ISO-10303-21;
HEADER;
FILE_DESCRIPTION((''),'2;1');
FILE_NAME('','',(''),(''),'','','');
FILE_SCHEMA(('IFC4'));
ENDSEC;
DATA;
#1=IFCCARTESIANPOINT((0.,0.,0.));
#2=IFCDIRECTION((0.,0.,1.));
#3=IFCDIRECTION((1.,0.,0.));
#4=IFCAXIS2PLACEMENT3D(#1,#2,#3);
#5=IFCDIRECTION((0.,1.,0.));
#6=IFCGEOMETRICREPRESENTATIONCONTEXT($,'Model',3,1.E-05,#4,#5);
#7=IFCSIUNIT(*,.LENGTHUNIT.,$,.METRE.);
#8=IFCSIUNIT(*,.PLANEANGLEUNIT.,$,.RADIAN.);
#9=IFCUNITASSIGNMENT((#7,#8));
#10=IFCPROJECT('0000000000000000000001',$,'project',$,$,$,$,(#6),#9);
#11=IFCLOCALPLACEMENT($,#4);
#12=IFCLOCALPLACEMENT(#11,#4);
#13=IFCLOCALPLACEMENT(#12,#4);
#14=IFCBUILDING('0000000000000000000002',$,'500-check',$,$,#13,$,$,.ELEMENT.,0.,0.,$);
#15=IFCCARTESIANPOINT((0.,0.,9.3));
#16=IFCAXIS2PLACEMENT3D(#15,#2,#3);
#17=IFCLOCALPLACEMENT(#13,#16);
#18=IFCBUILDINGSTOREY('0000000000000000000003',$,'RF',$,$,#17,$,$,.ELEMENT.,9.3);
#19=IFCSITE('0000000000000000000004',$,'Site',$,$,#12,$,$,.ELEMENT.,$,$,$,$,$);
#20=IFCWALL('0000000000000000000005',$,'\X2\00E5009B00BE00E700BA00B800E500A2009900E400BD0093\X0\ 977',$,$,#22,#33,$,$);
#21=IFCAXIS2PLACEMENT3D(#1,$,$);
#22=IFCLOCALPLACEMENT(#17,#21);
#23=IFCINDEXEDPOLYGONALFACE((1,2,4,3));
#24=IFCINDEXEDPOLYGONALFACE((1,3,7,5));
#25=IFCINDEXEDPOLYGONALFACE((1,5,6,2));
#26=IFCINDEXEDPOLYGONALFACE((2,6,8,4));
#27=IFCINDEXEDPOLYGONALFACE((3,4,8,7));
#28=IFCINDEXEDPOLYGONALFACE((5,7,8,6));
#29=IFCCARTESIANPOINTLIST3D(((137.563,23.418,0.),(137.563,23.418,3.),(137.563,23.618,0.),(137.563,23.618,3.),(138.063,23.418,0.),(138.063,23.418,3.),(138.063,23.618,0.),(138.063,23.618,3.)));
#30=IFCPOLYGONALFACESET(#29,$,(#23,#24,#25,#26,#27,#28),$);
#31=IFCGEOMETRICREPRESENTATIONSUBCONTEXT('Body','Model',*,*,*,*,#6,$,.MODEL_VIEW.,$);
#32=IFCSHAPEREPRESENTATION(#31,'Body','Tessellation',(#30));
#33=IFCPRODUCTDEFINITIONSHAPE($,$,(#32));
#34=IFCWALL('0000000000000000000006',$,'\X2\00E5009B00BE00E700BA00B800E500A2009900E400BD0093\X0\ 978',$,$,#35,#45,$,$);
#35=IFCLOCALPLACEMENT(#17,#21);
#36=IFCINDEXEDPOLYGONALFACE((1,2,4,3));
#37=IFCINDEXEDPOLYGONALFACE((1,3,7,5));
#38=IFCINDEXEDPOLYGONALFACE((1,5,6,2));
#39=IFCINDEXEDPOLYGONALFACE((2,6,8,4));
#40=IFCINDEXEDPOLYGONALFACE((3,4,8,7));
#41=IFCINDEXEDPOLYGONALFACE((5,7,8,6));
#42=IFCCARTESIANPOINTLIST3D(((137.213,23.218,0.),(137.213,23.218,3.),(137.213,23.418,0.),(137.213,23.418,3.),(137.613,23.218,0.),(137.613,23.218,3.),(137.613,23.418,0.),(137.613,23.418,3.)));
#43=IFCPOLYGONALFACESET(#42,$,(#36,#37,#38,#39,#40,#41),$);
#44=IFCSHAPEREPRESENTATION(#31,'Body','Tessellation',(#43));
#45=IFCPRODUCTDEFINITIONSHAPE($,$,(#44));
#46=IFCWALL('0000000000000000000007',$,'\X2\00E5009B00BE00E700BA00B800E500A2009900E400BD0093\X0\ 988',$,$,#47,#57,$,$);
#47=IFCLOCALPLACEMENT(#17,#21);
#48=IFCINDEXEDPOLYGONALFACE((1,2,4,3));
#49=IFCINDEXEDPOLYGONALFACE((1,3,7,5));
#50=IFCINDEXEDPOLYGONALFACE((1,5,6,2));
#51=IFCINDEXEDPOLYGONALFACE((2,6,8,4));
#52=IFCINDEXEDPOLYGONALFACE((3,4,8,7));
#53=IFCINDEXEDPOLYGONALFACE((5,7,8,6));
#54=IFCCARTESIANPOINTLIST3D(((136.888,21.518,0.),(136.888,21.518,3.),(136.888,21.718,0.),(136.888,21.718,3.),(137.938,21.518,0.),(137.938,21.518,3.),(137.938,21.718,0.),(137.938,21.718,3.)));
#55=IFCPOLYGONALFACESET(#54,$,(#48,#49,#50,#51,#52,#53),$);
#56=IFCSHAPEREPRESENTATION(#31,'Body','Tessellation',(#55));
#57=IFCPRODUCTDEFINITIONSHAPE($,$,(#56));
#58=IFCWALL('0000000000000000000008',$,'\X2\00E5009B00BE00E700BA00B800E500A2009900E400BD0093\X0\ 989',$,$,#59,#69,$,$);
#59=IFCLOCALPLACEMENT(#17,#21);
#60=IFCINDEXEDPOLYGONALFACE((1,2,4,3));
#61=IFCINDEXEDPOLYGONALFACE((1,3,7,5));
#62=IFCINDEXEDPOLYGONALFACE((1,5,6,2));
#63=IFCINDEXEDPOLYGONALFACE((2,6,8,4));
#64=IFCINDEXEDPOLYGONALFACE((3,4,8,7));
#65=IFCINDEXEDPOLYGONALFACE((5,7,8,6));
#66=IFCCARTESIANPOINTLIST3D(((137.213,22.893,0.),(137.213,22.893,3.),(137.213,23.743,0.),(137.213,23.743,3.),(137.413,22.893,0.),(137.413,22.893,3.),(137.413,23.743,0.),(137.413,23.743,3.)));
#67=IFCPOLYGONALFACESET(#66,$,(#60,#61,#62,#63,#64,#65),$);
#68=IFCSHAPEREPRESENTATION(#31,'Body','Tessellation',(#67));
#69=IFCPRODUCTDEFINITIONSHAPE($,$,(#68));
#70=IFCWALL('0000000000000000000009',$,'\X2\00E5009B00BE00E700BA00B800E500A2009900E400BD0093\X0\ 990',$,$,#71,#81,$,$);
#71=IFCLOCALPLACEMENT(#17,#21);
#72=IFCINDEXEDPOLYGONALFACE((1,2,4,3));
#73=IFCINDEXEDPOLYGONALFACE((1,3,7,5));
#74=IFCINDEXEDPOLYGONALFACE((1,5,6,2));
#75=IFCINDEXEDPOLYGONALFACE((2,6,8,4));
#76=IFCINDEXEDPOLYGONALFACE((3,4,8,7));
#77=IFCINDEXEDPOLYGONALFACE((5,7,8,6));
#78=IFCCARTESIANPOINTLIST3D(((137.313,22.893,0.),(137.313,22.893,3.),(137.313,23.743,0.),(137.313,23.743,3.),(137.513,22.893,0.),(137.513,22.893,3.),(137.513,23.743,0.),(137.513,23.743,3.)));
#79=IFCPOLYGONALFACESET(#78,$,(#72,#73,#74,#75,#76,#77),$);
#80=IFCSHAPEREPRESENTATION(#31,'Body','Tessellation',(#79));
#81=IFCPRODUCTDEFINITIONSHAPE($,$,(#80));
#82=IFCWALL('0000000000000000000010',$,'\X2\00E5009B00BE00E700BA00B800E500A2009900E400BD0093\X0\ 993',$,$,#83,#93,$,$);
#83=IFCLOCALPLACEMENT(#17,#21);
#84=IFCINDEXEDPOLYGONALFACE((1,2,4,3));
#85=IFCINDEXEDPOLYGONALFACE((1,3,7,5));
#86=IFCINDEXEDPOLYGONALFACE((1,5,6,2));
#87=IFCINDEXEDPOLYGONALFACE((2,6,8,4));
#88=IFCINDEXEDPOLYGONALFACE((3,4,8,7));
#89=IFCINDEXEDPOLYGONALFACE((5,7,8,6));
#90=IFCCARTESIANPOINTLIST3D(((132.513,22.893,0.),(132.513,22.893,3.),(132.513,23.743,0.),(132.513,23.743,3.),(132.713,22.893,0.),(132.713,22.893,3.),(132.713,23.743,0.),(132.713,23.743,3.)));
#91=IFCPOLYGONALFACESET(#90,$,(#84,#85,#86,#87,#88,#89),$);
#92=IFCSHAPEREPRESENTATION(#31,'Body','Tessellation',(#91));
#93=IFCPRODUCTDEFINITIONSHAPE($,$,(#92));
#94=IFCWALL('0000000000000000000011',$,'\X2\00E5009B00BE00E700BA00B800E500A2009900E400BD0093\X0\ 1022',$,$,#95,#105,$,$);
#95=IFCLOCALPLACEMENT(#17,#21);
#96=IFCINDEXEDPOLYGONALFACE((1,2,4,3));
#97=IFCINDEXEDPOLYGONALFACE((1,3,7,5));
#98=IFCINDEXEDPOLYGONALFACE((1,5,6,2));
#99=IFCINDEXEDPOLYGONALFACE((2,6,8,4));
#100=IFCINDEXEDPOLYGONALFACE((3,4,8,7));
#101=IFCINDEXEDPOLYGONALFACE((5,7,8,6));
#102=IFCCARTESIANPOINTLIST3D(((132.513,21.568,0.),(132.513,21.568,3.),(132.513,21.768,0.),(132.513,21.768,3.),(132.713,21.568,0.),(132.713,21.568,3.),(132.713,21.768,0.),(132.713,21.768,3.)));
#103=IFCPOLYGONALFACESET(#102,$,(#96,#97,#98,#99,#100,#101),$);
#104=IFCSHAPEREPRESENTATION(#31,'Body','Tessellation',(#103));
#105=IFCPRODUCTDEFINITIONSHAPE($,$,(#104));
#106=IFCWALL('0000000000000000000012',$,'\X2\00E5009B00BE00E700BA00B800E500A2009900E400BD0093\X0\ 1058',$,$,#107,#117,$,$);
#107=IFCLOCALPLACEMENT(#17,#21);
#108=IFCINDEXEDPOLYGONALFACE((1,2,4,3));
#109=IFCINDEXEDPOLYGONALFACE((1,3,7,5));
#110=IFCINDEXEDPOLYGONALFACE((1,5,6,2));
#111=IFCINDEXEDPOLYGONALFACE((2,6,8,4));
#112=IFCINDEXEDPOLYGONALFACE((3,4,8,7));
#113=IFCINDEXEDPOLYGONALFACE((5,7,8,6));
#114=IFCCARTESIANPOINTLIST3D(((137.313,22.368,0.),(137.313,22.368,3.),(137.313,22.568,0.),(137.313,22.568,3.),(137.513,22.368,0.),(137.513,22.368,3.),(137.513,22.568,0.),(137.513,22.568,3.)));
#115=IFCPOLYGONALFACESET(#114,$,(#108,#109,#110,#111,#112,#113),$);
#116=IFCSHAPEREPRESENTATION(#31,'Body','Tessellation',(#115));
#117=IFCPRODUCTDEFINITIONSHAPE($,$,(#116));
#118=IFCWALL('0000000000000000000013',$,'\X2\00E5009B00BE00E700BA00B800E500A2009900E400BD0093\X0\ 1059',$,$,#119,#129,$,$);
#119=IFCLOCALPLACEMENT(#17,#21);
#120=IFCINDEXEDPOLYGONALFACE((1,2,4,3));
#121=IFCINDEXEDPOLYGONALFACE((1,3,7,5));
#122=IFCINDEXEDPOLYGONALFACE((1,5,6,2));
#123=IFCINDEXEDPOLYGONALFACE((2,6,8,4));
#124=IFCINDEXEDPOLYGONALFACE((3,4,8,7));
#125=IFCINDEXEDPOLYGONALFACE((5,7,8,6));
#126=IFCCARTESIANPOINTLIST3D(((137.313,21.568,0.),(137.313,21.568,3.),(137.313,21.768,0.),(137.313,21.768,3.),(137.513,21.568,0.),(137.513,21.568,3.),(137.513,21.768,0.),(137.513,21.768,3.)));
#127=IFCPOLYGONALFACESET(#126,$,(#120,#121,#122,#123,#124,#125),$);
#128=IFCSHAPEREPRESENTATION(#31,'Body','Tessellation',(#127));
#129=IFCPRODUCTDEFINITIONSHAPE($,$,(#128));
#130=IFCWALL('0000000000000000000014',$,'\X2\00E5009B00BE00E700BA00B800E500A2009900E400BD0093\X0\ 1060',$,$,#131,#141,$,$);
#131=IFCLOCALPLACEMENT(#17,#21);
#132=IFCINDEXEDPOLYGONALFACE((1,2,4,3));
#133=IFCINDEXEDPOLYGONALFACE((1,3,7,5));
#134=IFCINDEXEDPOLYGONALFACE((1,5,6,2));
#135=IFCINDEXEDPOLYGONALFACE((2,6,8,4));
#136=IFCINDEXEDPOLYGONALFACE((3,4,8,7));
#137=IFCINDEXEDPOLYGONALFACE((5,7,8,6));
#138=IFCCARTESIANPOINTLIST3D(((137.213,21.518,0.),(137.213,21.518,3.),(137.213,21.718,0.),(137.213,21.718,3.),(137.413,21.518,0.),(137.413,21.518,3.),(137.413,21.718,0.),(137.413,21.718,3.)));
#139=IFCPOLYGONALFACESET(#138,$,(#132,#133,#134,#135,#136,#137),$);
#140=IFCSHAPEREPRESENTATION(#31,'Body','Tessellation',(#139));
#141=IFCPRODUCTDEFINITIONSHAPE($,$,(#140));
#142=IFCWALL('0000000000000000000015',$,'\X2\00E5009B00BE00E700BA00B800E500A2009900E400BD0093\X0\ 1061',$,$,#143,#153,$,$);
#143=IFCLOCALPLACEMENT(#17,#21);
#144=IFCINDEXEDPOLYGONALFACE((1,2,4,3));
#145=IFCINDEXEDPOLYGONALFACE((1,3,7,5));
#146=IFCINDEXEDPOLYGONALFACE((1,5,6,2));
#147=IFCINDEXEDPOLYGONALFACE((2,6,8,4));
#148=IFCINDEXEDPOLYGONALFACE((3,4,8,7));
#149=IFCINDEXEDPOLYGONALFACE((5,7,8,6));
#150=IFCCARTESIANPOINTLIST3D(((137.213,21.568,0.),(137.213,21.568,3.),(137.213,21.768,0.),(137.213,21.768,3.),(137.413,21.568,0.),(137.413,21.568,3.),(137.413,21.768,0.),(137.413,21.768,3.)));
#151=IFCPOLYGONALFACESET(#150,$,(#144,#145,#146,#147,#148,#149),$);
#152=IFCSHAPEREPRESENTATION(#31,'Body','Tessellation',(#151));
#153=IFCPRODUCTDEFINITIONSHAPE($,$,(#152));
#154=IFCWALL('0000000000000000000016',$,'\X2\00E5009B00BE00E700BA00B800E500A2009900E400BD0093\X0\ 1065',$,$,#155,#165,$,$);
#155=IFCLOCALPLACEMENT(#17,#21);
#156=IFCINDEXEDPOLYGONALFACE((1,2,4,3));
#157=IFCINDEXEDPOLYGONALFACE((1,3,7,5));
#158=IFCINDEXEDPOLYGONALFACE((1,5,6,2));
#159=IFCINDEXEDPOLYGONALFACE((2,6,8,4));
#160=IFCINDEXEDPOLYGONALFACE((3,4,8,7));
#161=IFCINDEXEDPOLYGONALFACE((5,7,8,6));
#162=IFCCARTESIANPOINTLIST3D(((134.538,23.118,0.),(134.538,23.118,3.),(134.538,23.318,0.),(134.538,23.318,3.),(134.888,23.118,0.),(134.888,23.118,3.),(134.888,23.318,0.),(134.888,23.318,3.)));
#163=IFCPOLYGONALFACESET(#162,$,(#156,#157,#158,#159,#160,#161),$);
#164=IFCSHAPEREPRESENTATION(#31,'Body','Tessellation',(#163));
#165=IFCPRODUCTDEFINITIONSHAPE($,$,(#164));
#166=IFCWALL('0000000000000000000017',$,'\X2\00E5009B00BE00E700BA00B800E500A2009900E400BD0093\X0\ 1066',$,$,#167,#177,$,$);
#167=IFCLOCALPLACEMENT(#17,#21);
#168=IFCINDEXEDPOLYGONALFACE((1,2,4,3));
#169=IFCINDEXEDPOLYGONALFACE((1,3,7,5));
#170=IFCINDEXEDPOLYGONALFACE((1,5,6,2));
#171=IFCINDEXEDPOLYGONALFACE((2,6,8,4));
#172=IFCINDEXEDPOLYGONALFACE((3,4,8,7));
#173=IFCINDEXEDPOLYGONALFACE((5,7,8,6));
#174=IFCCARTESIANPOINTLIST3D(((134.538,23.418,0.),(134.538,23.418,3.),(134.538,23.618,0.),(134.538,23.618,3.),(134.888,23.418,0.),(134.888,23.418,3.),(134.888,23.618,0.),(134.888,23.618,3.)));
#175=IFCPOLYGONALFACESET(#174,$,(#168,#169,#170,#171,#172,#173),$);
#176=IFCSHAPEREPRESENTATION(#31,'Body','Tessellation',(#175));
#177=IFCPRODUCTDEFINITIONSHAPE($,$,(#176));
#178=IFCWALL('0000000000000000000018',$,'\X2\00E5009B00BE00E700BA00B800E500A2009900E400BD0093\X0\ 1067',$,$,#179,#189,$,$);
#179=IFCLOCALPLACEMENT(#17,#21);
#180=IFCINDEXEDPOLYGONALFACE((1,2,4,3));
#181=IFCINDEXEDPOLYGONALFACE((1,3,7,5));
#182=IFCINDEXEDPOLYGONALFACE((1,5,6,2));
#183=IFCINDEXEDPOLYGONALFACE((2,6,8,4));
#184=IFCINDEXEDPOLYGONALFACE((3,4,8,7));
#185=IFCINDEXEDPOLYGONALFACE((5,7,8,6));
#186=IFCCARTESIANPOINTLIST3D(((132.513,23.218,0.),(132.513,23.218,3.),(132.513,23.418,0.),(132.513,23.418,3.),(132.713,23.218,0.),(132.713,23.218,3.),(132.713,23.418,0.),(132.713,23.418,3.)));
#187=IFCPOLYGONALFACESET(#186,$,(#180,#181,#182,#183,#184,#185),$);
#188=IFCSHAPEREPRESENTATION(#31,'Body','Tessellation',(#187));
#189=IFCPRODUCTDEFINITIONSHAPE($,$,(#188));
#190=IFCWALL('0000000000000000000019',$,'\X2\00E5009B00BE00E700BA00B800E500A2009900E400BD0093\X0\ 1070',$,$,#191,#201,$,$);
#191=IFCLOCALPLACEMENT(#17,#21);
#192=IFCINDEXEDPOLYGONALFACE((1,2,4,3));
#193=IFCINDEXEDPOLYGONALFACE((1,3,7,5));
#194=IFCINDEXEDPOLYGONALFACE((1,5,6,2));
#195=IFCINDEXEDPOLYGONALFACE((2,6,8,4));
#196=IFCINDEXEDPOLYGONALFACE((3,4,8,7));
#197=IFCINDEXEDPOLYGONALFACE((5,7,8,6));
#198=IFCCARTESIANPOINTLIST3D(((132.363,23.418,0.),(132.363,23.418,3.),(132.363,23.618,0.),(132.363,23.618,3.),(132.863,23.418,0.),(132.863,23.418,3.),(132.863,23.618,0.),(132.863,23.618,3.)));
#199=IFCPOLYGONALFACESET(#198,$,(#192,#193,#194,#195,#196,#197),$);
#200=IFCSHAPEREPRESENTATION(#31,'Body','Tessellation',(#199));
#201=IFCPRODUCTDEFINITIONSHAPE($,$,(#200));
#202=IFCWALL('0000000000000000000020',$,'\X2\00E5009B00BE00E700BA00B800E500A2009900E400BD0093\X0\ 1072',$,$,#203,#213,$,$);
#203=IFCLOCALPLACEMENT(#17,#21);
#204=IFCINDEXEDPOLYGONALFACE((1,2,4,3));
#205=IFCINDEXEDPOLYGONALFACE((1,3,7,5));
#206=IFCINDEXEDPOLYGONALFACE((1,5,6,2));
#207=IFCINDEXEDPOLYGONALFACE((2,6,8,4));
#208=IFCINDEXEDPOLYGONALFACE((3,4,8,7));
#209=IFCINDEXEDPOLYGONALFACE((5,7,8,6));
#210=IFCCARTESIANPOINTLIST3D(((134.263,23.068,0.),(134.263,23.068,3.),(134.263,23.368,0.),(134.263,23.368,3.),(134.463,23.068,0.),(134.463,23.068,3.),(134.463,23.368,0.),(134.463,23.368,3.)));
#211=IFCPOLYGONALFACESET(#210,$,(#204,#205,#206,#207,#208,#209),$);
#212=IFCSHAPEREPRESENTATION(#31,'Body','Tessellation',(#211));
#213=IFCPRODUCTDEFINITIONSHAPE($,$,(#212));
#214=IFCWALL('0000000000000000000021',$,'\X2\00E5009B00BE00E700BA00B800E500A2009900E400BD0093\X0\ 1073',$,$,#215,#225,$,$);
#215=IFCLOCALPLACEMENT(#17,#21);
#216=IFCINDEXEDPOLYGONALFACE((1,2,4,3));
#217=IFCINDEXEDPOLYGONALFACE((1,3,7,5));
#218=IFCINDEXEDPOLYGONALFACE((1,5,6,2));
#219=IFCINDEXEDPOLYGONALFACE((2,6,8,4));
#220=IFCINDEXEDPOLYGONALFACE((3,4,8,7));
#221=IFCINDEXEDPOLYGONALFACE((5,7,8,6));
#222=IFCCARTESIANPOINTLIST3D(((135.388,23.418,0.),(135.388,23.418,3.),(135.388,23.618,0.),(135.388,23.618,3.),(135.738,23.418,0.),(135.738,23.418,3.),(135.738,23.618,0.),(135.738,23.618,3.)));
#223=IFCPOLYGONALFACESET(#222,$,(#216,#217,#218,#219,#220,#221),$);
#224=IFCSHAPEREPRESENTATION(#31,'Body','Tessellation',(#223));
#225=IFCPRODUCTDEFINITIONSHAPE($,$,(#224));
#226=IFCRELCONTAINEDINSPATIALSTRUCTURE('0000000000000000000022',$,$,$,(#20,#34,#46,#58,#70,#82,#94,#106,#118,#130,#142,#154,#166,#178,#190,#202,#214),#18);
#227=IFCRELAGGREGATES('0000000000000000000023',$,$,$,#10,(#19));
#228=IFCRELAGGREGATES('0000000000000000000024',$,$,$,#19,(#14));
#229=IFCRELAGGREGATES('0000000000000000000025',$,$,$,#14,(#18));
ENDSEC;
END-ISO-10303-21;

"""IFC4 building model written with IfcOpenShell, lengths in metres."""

from ifc_helpers import new_model, si_unit, direction, frame, frame_2d, origin_with_axes, place, context, subcontext, project, spatial, rectangle, extrude, element, save


model = new_model("IFC4")

# Units and contexts
model_context = context("Model", 3, precision=1e-05, world=origin_with_axes(), true_north=direction((0.0, 1.0, 0.0)))
body_context = subcontext(model_context, "Body", "Model", "MODEL_VIEW")
ifc_project = project(units=[si_unit("LENGTHUNIT", "METRE"), si_unit("PLANEANGLEUNIT", "RADIAN")], contexts=[model_context])

# Site, building, storey
placement = place(None, origin_with_axes())
site_placement = place(placement, origin_with_axes())
site = spatial("IfcSite", under=ifc_project, at=site_placement, Name="Site", CompositionType="ELEMENT")
building_placement = place(site_placement, origin_with_axes())
building = spatial("IfcBuilding", under=site, at=building_placement, Name="500-check", CompositionType="ELEMENT", ElevationOfRefHeight=0.0, ElevationOfTerrain=0.0)
storey_placement = place(building_placement, frame((0.0, 0.0, 9.3), z_axis=(0.0, 0.0, 1.0), x_axis=(1.0, 0.0, 0.0)))
storey = spatial("IfcBuildingStorey", under=building, at=storey_placement, Name="RF", CompositionType="ELEMENT", Elevation=9.3)

# Walls
wall_1_placement = place(storey_placement, frame((137.813, 23.518, 0.0), z_axis=(0.0, 0.0, 1.0), x_axis=(-1.0, 0.0, 0.0)))
element("IfcWall", 1, at=wall_1_placement, inside=storey, Name="å\u009b¾çº¸å¢\u0099ä½\u0093 977", context=body_context, shape_type="SweptSolid", body=[
    extrude(rectangle(XDim=0.5, YDim=0.2, at=frame_2d((0.0, 0.0), x_axis=(1.0, 0.0, 0.0))), frame((0.0, 0.0, 0.0), z_axis=(0.0, 0.0, 1.0)), (0.0, 0.0, 1.0), 3.0),
])
wall_2_placement = place(storey_placement, frame((137.413, 23.318, 0.0), z_axis=(0.0, 0.0, 1.0), x_axis=(1.0, 0.0, 0.0)))
element("IfcWall", 2, at=wall_2_placement, inside=storey, Name="å\u009b¾çº¸å¢\u0099ä½\u0093 978", context=body_context, shape_type="SweptSolid", body=[
    extrude(rectangle(XDim=0.4, YDim=0.2, at=frame_2d((0.0, 0.0), x_axis=(1.0, 0.0, 0.0))), frame((0.0, 0.0, 0.0), z_axis=(0.0, 0.0, 1.0)), (0.0, 0.0, 1.0), 3.0),
])
wall_3_placement = place(storey_placement, frame((137.413, 21.618, 0.0), z_axis=(0.0, 0.0, 1.0), x_axis=(1.0, 0.0, 0.0)))
element("IfcWall", 3, at=wall_3_placement, inside=storey, Name="å\u009b¾çº¸å¢\u0099ä½\u0093 988", context=body_context, shape_type="SweptSolid", body=[
    extrude(rectangle(XDim=1.05, YDim=0.2, at=frame_2d((0.0, 0.0), x_axis=(1.0, 0.0, 0.0))), frame((0.0, 0.0, 0.0), z_axis=(0.0, 0.0, 1.0)), (0.0, 0.0, 1.0), 3.0),
])
for number, where, z_axis, x_axis, name in (
    (4, (137.313, 23.318, 0.0), (0.0, 0.0, 1.0), (0.0, -1.0, 0.0), "å\u009b¾çº¸å¢\u0099ä½\u0093 989"),
    (5, (137.413, 23.318, 0.0), (0.0, 0.0, 1.0), (0.0, -1.0, 0.0), "å\u009b¾çº¸å¢\u0099ä½\u0093 990"),
    (6, (132.613, 23.318, 0.0), (0.0, 0.0, 1.0), (0.0, -1.0, 0.0), "å\u009b¾çº¸å¢\u0099ä½\u0093 993"),
):
    element("IfcWall", number, at=place(storey_placement, frame(where, z_axis=z_axis, x_axis=x_axis)), inside=storey, Name=name, context=body_context, shape_type="SweptSolid", body=[
        extrude(rectangle(XDim=0.85, YDim=0.2, at=frame_2d((0.0, 0.0), x_axis=(1.0, 0.0, 0.0))), frame((0.0, 0.0, 0.0), z_axis=(0.0, 0.0, 1.0)), (0.0, 0.0, 1.0), 3.0),
    ])
for number, where, z_axis, x_axis, name in (
    (7, (132.613, 21.668, 0.0), (0.0, 0.0, 1.0), (0.0, -1.0, 0.0), "å\u009b¾çº¸å¢\u0099ä½\u0093 1022"),
    (8, (137.413, 22.468, 0.0), (0.0, 0.0, 1.0), (-1.0, 0.0, 0.0), "å\u009b¾çº¸å¢\u0099ä½\u0093 1058"),
    (9, (137.413, 21.668, 0.0), (0.0, 0.0, 1.0), (-1.0, 0.0, 0.0), "å\u009b¾çº¸å¢\u0099ä½\u0093 1059"),
    (10, (137.313, 21.618, 0.0), (0.0, 0.0, 1.0), (0.0, -1.0, 0.0), "å\u009b¾çº¸å¢\u0099ä½\u0093 1060"),
    (11, (137.313, 21.668, 0.0), (0.0, 0.0, 1.0), (0.0, -1.0, 0.0), "å\u009b¾çº¸å¢\u0099ä½\u0093 1061"),
):
    element("IfcWall", number, at=place(storey_placement, frame(where, z_axis=z_axis, x_axis=x_axis)), inside=storey, Name=name, context=body_context, shape_type="SweptSolid", body=[
        extrude(rectangle(XDim=0.2, YDim=0.2, at=frame_2d((0.0, 0.0), x_axis=(1.0, 0.0, 0.0))), frame((0.0, 0.0, 0.0), z_axis=(0.0, 0.0, 1.0)), (0.0, 0.0, 1.0), 3.0),
    ])
for number, where, z_axis, x_axis, name in (
    (12, (134.713, 23.218, 0.0), (0.0, 0.0, 1.0), (-1.0, 0.0, 0.0), "å\u009b¾çº¸å¢\u0099ä½\u0093 1065"),
    (13, (134.713, 23.518, 0.0), (0.0, 0.0, 1.0), (-1.0, 0.0, 0.0), "å\u009b¾çº¸å¢\u0099ä½\u0093 1066"),
):
    element("IfcWall", number, at=place(storey_placement, frame(where, z_axis=z_axis, x_axis=x_axis)), inside=storey, Name=name, context=body_context, shape_type="SweptSolid", body=[
        extrude(rectangle(XDim=0.35, YDim=0.2, at=frame_2d((0.0, 0.0), x_axis=(1.0, 0.0, 0.0))), frame((0.0, 0.0, 0.0), z_axis=(0.0, 0.0, 1.0)), (0.0, 0.0, 1.0), 3.0),
    ])
wall_4_placement = place(storey_placement, frame((132.613, 23.318, 0.0), z_axis=(0.0, 0.0, 1.0), x_axis=(0.0, 1.0, 0.0)))
element("IfcWall", 14, at=wall_4_placement, inside=storey, Name="å\u009b¾çº¸å¢\u0099ä½\u0093 1067", context=body_context, shape_type="SweptSolid", body=[
    extrude(rectangle(XDim=0.2, YDim=0.2, at=frame_2d((0.0, 0.0), x_axis=(1.0, 0.0, 0.0))), frame((0.0, 0.0, 0.0), z_axis=(0.0, 0.0, 1.0)), (0.0, 0.0, 1.0), 3.0),
])
wall_5_placement = place(storey_placement, frame((132.613, 23.518, 0.0), z_axis=(0.0, 0.0, 1.0), x_axis=(-1.0, 0.0, 0.0)))
element("IfcWall", 15, at=wall_5_placement, inside=storey, Name="å\u009b¾çº¸å¢\u0099ä½\u0093 1070", context=body_context, shape_type="SweptSolid", body=[
    extrude(rectangle(XDim=0.5, YDim=0.2, at=frame_2d((0.0, 0.0), x_axis=(1.0, 0.0, 0.0))), frame((0.0, 0.0, 0.0), z_axis=(0.0, 0.0, 1.0)), (0.0, 0.0, 1.0), 3.0),
])
wall_6_placement = place(storey_placement, frame((134.363, 23.218, 0.0), z_axis=(0.0, 0.0, 1.0), x_axis=(0.0, 1.0, 0.0)))
element("IfcWall", 16, at=wall_6_placement, inside=storey, Name="å\u009b¾çº¸å¢\u0099ä½\u0093 1072", context=body_context, shape_type="SweptSolid", body=[
    extrude(rectangle(XDim=0.3, YDim=0.2, at=frame_2d((0.0, 0.0), x_axis=(1.0, 0.0, 0.0))), frame((0.0, 0.0, 0.0), z_axis=(0.0, 0.0, 1.0)), (0.0, 0.0, 1.0), 3.0),
])
for number, where, z_axis, x_axis, name in (
    (17, (135.563, 23.518, 0.0), (0.0, 0.0, 1.0), (-1.0, 0.0, 0.0), "å\u009b¾çº¸å¢\u0099ä½\u0093 1073"),
):
    element("IfcWall", number, at=place(storey_placement, frame(where, z_axis=z_axis, x_axis=x_axis)), inside=storey, Name=name, context=body_context, shape_type="SweptSolid", body=[
        extrude(rectangle(XDim=0.35, YDim=0.2, at=frame_2d((0.0, 0.0), x_axis=(1.0, 0.0, 0.0))), frame((0.0, 0.0, 0.0), z_axis=(0.0, 0.0, 1.0)), (0.0, 0.0, 1.0), 3.0),
    ])

save(model, "model.ifc")
